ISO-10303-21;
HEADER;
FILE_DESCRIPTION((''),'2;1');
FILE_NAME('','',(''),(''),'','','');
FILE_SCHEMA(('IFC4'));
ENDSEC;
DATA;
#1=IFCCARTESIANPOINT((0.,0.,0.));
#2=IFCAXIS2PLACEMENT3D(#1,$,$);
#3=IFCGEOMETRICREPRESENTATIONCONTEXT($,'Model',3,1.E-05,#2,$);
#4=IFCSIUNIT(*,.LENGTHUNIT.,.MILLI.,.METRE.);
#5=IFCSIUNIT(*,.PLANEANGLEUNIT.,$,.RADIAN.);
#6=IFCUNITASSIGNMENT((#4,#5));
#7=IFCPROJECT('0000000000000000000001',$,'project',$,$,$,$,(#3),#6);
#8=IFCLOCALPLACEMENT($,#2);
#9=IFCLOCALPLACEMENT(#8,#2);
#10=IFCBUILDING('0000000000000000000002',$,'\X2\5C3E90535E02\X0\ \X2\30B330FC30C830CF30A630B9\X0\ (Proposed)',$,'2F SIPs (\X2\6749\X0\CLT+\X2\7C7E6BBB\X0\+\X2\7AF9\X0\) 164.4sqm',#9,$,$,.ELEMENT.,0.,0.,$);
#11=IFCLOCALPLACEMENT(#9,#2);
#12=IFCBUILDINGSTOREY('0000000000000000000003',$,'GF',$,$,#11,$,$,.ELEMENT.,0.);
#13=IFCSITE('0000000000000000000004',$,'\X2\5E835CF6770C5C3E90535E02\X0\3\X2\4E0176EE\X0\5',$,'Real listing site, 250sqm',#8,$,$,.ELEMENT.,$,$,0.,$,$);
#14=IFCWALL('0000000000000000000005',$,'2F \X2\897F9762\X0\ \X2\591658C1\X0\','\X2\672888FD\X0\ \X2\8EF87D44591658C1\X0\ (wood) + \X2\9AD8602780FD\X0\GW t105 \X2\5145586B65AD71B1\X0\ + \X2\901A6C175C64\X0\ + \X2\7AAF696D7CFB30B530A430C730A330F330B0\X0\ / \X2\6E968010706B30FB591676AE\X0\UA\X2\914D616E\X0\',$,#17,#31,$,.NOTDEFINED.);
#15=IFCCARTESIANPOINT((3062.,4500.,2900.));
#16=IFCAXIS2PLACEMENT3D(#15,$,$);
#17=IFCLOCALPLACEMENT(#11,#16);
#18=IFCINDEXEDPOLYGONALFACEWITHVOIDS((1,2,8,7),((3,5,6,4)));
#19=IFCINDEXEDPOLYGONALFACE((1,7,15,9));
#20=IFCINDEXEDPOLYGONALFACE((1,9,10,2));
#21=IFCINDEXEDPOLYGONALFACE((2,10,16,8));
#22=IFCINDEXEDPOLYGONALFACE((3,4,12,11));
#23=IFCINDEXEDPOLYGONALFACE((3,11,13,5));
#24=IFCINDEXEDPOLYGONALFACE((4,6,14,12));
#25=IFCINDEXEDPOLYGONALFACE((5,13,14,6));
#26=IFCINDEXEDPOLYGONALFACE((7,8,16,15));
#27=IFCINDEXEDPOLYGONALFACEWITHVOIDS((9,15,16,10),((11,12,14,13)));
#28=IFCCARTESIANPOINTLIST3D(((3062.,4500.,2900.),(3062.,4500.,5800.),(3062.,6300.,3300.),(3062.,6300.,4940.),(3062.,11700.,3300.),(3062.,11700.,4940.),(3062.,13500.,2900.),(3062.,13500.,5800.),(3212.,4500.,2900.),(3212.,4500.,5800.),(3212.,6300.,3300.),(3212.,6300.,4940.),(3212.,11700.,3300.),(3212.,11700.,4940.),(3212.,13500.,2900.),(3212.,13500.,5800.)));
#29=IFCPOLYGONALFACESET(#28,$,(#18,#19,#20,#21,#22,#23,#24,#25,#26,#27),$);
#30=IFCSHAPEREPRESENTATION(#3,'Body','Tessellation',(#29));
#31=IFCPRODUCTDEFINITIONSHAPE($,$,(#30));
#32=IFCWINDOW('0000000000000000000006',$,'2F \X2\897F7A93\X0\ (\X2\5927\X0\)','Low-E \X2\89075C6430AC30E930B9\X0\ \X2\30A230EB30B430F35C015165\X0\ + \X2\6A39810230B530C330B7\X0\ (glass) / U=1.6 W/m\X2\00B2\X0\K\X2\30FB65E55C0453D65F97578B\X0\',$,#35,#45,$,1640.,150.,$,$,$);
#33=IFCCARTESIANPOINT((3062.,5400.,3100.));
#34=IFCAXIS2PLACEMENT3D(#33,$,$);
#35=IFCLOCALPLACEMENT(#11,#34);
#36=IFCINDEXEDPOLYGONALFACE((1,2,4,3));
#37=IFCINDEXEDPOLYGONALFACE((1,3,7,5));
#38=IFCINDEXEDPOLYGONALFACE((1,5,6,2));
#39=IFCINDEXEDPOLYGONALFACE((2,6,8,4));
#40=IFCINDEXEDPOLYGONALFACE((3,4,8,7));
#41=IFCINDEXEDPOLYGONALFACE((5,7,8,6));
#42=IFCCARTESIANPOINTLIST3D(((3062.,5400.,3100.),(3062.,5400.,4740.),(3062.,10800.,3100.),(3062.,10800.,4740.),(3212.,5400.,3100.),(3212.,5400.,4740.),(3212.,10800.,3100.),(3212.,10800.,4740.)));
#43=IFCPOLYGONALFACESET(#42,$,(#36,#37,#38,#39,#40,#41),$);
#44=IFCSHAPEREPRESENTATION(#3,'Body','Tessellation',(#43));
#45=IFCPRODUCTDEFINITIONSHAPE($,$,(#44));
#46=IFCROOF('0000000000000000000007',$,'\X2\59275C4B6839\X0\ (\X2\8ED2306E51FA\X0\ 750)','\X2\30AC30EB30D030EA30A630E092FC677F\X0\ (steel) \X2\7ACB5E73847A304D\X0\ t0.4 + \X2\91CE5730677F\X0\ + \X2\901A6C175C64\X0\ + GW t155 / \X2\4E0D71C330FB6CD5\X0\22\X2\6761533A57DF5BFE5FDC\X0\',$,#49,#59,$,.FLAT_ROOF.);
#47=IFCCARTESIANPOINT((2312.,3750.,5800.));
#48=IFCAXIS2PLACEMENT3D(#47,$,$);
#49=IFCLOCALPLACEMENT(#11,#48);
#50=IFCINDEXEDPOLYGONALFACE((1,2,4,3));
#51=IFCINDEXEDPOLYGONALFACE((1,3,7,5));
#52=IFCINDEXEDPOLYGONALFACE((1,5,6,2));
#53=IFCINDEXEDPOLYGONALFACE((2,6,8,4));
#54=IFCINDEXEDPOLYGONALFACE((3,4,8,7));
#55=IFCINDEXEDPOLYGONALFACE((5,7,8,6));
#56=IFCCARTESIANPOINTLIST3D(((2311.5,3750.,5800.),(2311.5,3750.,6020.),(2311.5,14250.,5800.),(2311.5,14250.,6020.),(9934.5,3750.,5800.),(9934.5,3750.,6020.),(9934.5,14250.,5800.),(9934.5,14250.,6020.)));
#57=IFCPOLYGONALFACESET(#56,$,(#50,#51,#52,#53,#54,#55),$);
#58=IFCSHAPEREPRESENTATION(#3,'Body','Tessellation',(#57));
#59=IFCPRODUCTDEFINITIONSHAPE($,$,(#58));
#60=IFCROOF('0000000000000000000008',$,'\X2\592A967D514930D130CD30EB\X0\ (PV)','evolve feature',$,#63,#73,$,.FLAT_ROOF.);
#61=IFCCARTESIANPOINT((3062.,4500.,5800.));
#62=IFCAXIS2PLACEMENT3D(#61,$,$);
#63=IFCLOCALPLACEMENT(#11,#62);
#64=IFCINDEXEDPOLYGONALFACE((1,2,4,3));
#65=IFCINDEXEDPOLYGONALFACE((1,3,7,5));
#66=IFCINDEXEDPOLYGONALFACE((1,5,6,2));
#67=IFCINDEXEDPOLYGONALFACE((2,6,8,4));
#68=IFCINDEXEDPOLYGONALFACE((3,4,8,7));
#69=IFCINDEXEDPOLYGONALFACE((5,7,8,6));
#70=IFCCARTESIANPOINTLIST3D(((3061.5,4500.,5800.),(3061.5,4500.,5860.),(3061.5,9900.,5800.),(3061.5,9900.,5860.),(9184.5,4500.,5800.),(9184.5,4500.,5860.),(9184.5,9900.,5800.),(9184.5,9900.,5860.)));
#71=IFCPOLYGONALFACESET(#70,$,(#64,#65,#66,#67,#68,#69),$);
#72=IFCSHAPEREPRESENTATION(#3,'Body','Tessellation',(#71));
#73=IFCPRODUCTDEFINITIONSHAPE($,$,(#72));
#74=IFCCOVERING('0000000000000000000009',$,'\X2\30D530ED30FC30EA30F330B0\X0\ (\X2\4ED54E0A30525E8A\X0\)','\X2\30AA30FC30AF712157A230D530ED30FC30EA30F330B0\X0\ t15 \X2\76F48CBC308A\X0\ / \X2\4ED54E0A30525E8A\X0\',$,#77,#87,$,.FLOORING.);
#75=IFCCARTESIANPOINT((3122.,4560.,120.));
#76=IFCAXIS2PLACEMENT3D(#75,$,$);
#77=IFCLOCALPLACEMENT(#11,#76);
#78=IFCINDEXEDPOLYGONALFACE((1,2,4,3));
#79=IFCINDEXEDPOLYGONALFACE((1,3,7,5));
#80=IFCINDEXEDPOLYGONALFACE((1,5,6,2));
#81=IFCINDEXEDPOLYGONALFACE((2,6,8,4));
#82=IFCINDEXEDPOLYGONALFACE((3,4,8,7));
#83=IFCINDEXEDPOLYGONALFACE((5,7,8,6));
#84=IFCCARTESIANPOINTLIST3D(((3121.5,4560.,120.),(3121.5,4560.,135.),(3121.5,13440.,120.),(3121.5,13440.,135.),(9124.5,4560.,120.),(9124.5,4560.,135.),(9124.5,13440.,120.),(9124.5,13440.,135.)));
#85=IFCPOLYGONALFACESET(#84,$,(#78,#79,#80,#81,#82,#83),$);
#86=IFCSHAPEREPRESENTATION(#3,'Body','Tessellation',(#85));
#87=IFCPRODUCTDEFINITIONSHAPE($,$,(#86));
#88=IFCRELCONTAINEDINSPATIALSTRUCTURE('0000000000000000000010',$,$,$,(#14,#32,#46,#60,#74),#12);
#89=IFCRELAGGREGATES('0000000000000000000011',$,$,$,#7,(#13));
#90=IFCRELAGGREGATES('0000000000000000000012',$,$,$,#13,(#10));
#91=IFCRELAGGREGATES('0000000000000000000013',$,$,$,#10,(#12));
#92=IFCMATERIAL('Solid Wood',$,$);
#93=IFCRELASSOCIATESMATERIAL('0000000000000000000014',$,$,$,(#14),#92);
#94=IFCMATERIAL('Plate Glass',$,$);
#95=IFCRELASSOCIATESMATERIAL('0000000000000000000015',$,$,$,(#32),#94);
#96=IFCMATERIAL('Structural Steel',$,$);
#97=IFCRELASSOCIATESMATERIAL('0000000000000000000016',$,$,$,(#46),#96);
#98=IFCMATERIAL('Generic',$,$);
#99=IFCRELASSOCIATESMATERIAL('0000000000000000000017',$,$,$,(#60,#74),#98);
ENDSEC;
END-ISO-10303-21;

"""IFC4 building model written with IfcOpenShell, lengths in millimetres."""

from ifc_helpers import new_model, si_unit, frame, frame_2d, origin, place, context, project, spatial, rectangle, extrude, material, element, fill, save


model = new_model("IFC4")

# Units and contexts
model_context = context("Model", 3, precision=1e-05, world=origin())
ifc_project = project(units=[si_unit("LENGTHUNIT", "METRE", prefix="MILLI"), si_unit("PLANEANGLEUNIT", "RADIAN")], contexts=[model_context])

# Site, building, storey
site_placement = place(None, origin())
site = spatial("IfcSite", under=ifc_project, at=site_placement, Name="広島県尾道市3丁目5", ObjectType="Real listing site, 250sqm", CompositionType="ELEMENT", RefElevation=0.0)
building_placement = place(site_placement, origin())
building = spatial("IfcBuilding", under=site, at=building_placement, Name="尾道市 コートハウス (Proposed)", ObjectType="2F SIPs (杉CLT+籾殻+竹) 164.4sqm", CompositionType="ELEMENT", ElevationOfRefHeight=0.0, ElevationOfTerrain=0.0)
storey_placement = place(building_placement, origin())
storey = spatial("IfcBuildingStorey", under=building, at=storey_placement, Name="GF", CompositionType="ELEMENT", Elevation=0.0)

# Shared definitions
ifc_material_1 = material(Name="Solid Wood")
ifc_material_2 = material(Name="Generic")

# Shared definitions
ifc_material_3 = material(Name="Plate Glass")

# Wall, opening, window
wall_1_placement = place(storey_placement, frame((3062.0, 4500.0, 2900.0)))
wall_1 = element("IfcWall", 1, at=wall_1_placement, inside=storey, material=ifc_material_1, Name="2F 西面 外壁", Description="木製 軸組外壁 (wood) + 高性能GW t105 充填断熱 + 通気層 + 窯業系サイディング / 準耐火・外皮UA配慮", PredefinedType="NOTDEFINED", context=model_context, shape_type="SweptSolid", body=[
    extrude(rectangle(XDim=150.0, YDim=9000.0, at=frame_2d((75.0, 4500.0))), frame((3062.0, 4500.0, 2900.0)), (0.0, 0.0, 1.0), 2900.0),
])
opening_1_placement = place(storey_placement, frame((3062.0, 5400.0, 3100.0)))
opening_1 = element("IfcOpeningElement", 2, at=opening_1_placement, cuts=wall_1, PredefinedType="NOTDEFINED", context=model_context, shape_type="SweptSolid", body=[
    extrude(rectangle(XDim=150.0, YDim=5400.0, at=frame_2d((75.0, 2700.0))), frame((3062.0, 5400.0, 3100.0)), (0.0, 0.0, 1.0), 1640.0),
])
window_1_placement = place(storey_placement, frame((3062.0, 5400.0, 3100.0)))
window_1 = element("IfcWindow", 3, at=window_1_placement, inside=storey, material=ifc_material_3, Name="2F 西窓 (大)", Description="Low-E 複層ガラス アルゴン封入 + 樹脂サッシ (glass) / U=1.6 W/m²K・日射取得型", OverallHeight=1640.0, OverallWidth=150.0, context=model_context, shape_type="SweptSolid", body=[
    extrude(rectangle(XDim=150.0, YDim=5400.0, at=frame_2d((75.0, 2700.0))), frame((3062.0, 5400.0, 3100.0)), (0.0, 0.0, 1.0), 1640.0),
])
fill(opening_1, window_1)

# Roofs
ifc_material_4 = material(Name="Structural Steel")
roof_1_placement = place(storey_placement, frame((2312.0, 3750.0, 5800.0)))
element("IfcRoof", 4, at=roof_1_placement, inside=storey, material=ifc_material_4, Name="大屋根 (軒の出 750)", Description="ガルバリウム鋼板 (steel) 立平葺き t0.4 + 野地板 + 通気層 + GW t155 / 不燃・法22条区域対応", PredefinedType="FLAT_ROOF", context=model_context, shape_type="SweptSolid", body=[
    extrude(rectangle(XDim=7623.0, YDim=10500.0, at=frame_2d((3811.0, 5250.0))), frame((2312.0, 3750.0, 5800.0)), (0.0, 0.0, 1.0), 220.0),
])
roof_2_placement = place(storey_placement, frame((3062.0, 4500.0, 5800.0)))
element("IfcRoof", 5, at=roof_2_placement, inside=storey, material=ifc_material_2, Name="太陽光パネル (PV)", Description="evolve feature", PredefinedType="FLAT_ROOF", context=model_context, shape_type="SweptSolid", body=[
    extrude(rectangle(XDim=6123.0, YDim=5400.0, at=frame_2d((3061.0, 2700.0))), frame((3062.0, 4500.0, 5800.0)), (0.0, 0.0, 1.0), 60.0),
])

# Covering
covering_placement = place(storey_placement, frame((3122.0, 4560.0, 120.0)))
element("IfcCovering", 6, at=covering_placement, inside=storey, material=ifc_material_2, Name="フローリング (仕上げ床)", Description="オーク無垢フローリング t15 直貼り / 仕上げ床", PredefinedType="FLOORING", context=model_context, shape_type="SweptSolid", body=[
    extrude(rectangle(XDim=6003.0, YDim=8880.0, at=frame_2d((3001.0, 4440.0))), frame((3122.0, 4560.0, 120.0)), (0.0, 0.0, 1.0), 15.0),
])

save(model, "model.ifc")
